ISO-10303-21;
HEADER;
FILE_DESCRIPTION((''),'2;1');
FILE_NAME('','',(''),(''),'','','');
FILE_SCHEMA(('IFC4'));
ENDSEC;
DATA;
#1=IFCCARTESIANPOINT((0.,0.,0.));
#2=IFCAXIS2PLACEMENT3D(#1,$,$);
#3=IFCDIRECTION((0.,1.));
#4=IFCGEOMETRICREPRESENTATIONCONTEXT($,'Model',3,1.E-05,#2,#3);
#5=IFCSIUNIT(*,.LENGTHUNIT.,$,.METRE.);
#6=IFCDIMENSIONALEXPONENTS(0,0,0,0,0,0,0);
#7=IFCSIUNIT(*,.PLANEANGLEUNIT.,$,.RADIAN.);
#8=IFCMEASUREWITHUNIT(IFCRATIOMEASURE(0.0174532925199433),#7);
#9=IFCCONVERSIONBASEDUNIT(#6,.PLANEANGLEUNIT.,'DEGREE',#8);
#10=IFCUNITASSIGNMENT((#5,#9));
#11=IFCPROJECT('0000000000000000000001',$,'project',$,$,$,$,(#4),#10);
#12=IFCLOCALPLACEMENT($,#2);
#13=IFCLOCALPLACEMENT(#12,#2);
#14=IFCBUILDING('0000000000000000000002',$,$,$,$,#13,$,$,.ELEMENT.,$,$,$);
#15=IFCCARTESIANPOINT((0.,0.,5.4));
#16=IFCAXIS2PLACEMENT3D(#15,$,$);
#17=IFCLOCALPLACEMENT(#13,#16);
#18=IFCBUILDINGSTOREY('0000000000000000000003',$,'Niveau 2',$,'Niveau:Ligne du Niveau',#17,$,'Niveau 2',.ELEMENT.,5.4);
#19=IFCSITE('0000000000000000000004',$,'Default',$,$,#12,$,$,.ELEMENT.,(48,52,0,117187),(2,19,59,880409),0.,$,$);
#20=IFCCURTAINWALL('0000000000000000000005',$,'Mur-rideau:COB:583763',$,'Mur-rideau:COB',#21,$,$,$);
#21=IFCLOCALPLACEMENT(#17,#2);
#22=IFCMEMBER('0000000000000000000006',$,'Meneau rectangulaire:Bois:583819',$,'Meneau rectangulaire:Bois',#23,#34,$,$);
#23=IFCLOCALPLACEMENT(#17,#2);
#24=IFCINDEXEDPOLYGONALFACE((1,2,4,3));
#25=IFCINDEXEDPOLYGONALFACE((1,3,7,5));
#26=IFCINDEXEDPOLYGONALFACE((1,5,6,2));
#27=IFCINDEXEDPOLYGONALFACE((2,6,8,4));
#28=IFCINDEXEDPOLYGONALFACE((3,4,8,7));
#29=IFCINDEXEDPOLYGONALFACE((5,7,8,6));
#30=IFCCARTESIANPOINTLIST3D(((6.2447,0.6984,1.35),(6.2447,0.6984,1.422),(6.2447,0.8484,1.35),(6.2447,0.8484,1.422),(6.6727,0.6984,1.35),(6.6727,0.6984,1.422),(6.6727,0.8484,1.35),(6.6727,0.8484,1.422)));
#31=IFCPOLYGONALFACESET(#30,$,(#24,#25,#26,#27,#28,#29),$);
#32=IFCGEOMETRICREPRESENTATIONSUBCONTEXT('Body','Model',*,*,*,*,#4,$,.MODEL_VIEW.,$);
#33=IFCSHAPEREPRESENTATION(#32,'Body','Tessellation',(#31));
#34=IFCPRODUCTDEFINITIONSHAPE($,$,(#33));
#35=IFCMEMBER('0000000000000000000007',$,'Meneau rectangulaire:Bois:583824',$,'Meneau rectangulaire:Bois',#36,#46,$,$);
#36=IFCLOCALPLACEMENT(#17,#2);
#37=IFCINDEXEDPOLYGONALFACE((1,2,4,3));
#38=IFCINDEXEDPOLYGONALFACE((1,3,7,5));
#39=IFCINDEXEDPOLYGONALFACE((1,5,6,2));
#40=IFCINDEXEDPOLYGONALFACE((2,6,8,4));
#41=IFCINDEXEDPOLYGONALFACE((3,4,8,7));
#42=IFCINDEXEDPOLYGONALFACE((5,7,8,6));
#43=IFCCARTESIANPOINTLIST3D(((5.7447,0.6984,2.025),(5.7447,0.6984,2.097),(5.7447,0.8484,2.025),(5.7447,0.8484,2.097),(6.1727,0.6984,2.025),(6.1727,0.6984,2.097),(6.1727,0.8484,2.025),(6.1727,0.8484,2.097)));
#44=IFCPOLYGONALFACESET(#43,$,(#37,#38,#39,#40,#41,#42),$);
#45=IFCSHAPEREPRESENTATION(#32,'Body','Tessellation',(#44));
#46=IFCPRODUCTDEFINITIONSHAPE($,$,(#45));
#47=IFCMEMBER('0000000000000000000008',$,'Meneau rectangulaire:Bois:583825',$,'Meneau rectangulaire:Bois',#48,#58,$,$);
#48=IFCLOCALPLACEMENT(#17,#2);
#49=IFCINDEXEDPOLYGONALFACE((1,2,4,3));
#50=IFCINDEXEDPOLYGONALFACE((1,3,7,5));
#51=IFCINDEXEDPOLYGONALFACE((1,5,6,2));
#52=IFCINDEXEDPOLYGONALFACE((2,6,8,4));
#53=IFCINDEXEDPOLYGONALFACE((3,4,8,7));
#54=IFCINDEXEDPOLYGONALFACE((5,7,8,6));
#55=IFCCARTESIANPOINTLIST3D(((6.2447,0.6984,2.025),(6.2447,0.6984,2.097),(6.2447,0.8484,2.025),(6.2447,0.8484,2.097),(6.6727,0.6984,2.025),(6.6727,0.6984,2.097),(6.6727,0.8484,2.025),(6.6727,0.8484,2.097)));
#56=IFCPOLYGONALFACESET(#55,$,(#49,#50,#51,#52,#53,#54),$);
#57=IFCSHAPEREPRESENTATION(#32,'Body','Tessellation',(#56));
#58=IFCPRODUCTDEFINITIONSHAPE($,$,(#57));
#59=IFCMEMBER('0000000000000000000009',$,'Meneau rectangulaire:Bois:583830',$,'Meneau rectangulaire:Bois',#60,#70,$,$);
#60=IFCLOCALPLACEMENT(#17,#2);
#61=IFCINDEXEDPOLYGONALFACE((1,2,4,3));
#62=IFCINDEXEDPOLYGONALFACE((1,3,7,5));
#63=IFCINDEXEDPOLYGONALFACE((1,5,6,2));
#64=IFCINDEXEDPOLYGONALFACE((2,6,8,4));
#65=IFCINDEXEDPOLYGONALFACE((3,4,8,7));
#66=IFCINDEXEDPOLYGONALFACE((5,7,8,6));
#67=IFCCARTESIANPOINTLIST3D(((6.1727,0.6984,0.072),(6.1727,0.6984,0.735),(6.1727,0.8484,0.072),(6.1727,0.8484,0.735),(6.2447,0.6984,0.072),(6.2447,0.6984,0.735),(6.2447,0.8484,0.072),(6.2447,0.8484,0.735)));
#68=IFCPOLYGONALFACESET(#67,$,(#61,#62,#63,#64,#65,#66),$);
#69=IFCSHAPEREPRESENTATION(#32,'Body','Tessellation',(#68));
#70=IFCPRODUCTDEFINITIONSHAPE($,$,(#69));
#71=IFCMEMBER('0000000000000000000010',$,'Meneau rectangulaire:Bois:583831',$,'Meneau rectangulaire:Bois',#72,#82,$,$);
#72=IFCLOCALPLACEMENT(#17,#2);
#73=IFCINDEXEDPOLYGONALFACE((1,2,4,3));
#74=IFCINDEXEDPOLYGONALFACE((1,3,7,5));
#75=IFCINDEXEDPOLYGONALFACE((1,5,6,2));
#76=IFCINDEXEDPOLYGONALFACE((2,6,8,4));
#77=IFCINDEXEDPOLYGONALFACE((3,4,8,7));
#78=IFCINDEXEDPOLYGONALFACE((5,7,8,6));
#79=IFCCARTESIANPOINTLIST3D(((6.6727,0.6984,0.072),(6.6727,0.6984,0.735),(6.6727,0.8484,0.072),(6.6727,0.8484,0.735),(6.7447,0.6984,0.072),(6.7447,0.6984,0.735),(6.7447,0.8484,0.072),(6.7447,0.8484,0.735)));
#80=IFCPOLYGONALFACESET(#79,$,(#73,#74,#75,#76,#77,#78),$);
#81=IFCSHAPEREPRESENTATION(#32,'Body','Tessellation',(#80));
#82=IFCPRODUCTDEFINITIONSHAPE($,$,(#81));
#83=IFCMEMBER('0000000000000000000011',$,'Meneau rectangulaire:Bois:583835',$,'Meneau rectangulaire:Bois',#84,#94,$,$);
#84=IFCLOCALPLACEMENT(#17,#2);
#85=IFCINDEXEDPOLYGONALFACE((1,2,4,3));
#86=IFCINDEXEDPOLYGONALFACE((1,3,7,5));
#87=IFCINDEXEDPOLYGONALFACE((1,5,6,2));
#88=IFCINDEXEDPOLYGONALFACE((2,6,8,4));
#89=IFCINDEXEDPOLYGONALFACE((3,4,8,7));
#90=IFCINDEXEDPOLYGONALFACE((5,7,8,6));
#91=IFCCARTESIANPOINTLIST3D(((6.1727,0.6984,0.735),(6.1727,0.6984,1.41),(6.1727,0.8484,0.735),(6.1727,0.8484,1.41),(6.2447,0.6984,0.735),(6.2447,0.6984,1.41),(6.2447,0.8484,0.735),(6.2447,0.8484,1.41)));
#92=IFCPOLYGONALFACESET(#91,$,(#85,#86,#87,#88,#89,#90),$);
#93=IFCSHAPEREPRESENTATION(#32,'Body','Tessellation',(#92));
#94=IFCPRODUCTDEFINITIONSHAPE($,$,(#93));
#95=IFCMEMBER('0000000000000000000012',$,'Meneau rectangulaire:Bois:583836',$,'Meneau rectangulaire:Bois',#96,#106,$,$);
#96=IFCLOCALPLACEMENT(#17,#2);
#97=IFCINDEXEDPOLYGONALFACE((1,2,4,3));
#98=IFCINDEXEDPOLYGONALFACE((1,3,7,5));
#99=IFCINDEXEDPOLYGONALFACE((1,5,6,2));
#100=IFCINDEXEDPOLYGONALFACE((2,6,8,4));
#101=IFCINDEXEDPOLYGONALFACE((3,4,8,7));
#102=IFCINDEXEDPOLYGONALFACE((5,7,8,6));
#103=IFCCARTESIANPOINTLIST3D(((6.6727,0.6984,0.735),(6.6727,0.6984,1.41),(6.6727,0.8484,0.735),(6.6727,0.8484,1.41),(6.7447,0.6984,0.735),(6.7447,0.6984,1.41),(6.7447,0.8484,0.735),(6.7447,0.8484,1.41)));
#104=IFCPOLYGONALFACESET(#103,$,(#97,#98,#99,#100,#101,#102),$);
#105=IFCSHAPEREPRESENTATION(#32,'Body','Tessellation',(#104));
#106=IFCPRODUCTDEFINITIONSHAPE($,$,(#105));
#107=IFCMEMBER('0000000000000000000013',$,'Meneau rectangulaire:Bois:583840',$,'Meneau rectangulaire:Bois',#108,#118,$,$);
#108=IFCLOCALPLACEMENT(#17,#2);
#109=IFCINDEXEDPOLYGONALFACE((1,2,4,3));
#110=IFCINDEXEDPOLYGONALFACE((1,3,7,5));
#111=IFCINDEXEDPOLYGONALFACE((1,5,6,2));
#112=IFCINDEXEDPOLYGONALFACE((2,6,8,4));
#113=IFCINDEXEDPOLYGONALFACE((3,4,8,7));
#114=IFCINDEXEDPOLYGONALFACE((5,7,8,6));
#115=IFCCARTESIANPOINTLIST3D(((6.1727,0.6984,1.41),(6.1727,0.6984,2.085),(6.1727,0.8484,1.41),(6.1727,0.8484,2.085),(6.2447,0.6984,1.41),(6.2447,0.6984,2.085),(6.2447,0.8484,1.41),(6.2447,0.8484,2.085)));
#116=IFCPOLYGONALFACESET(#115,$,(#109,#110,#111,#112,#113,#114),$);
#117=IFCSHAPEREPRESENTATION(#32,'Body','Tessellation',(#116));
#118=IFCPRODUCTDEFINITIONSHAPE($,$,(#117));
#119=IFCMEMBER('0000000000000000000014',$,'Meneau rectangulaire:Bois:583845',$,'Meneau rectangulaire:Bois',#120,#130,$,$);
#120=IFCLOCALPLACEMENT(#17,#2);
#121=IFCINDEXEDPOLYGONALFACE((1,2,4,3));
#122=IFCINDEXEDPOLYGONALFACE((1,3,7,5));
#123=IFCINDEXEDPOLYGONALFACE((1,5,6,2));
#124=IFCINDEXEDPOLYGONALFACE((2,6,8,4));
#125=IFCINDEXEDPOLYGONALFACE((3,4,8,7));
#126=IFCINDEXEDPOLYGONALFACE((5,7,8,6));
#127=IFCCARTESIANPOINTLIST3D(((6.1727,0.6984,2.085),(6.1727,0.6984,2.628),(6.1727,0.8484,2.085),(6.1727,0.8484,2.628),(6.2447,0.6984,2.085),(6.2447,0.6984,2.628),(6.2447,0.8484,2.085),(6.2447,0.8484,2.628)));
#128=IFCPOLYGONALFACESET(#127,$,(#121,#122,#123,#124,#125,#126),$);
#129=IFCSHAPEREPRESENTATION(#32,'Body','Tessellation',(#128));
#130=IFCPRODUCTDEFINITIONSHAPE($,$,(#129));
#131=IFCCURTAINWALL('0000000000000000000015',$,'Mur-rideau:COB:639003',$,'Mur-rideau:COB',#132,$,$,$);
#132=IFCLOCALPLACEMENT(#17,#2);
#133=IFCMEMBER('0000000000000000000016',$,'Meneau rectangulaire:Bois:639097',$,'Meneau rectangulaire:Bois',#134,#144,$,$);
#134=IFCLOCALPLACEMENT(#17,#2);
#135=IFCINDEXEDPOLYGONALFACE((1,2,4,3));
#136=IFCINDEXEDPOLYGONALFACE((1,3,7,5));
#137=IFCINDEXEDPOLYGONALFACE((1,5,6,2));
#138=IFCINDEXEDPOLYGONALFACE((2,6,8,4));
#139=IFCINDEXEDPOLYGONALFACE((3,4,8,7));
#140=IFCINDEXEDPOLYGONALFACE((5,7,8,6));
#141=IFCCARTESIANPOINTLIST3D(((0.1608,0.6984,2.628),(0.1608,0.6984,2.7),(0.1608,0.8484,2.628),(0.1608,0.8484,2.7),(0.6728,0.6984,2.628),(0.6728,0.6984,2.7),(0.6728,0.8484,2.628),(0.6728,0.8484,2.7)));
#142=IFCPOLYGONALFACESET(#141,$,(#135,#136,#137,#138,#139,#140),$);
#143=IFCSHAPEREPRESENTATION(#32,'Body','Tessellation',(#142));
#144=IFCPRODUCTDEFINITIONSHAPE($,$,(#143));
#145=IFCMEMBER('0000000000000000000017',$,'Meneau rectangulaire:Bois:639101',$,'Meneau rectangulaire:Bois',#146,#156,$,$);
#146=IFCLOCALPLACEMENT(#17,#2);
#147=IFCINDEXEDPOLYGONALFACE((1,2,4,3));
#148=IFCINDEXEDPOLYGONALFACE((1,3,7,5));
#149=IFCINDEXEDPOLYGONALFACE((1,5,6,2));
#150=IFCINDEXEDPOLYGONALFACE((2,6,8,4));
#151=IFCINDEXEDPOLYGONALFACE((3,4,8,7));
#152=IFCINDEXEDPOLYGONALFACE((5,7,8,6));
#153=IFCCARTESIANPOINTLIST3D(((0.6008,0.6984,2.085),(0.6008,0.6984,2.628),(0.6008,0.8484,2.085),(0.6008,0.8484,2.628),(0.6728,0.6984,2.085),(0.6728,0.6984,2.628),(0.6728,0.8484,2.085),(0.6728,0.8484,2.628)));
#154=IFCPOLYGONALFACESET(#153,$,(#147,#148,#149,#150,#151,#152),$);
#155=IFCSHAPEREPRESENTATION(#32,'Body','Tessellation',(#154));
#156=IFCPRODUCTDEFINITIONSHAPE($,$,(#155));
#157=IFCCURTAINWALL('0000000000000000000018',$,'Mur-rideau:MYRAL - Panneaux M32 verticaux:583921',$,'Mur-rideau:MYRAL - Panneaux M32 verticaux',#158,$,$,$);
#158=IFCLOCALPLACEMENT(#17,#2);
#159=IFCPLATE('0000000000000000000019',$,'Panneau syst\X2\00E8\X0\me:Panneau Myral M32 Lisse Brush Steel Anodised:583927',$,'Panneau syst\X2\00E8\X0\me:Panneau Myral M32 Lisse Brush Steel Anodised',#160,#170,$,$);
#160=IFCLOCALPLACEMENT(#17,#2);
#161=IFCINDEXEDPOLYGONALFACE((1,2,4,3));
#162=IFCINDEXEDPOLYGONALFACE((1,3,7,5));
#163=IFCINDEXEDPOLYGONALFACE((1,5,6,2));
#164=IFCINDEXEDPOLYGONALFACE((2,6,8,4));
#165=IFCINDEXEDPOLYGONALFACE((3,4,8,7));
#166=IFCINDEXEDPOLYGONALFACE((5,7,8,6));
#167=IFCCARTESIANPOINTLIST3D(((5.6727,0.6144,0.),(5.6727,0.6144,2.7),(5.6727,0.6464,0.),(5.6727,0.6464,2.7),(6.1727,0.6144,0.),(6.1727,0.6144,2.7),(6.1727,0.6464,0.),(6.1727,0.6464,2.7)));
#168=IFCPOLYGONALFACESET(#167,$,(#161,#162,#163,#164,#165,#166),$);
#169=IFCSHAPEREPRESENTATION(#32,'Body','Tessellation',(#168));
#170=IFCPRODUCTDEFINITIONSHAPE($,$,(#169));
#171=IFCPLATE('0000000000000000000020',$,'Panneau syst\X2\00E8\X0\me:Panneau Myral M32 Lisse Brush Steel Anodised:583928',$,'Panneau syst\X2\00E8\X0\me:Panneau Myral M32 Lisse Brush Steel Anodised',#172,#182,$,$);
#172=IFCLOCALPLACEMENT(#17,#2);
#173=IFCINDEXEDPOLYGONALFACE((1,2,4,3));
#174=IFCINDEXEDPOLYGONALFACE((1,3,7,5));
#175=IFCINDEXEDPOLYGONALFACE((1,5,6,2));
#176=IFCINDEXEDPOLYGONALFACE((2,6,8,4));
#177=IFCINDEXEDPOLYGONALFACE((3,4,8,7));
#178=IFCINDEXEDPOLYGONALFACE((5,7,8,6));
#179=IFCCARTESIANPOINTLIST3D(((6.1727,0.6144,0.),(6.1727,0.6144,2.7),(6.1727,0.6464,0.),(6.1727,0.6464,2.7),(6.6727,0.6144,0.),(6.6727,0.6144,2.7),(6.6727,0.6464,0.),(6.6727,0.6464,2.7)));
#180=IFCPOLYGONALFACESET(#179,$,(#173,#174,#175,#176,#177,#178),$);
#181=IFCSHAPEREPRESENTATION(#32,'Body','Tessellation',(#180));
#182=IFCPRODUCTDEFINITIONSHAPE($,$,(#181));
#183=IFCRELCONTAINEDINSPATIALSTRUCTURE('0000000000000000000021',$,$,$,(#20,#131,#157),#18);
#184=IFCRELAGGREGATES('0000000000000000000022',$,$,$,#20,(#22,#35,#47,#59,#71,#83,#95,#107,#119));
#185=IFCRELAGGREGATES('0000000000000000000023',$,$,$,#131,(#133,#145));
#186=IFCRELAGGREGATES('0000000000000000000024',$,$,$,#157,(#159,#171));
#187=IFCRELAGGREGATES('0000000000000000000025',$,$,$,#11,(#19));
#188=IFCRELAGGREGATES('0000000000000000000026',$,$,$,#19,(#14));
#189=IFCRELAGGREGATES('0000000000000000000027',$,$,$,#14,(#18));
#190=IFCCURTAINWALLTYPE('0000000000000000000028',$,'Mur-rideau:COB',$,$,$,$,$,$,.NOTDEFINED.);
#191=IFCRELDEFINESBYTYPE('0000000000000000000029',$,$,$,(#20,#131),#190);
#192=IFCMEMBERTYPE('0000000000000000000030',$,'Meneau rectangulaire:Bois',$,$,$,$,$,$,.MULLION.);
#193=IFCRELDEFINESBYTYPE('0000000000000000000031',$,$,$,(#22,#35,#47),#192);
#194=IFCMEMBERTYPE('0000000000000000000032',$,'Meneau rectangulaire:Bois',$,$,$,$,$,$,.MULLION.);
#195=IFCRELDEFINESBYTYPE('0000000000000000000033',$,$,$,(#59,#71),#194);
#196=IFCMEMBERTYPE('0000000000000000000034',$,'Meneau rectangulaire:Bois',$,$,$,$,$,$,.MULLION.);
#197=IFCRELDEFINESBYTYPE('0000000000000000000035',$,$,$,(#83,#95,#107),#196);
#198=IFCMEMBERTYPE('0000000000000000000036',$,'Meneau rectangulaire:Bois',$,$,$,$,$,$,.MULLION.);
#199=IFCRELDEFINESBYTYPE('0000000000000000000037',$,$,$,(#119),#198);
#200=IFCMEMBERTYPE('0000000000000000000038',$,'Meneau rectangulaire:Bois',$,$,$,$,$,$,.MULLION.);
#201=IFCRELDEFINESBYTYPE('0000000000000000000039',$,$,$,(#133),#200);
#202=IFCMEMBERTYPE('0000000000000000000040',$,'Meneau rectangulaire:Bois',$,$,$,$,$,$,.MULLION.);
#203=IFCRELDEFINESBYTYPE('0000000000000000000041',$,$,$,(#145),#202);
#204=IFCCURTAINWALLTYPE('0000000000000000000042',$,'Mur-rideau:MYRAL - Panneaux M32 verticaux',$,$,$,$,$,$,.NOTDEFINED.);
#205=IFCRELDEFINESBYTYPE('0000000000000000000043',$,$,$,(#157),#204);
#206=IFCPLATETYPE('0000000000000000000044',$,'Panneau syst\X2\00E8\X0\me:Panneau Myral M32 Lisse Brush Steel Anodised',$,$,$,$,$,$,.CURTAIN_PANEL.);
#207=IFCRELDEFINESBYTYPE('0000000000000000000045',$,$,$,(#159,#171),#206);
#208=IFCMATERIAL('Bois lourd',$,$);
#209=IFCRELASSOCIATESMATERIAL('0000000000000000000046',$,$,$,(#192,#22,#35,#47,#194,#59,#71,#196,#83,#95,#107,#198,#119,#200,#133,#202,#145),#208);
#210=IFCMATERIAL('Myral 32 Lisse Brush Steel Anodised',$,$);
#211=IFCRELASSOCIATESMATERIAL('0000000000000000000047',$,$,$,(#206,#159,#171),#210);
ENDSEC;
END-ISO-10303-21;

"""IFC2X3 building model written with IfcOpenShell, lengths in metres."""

from ifc_helpers import new_model, entity, si_unit, converted_unit, direction, frame, origin, origin_2d_with_axis, place, context, subcontext, project, spatial, rectangle, extrude, source, transform, mapped, material, type_object, type_shapes, element, aggregate, save


model = new_model("IFC2X3")

# Units and contexts
model_context = context("Model", 3, precision=1e-05, world=origin(), true_north=direction((0.0, 1.0)))
body_context = subcontext(model_context, "Body", "Model", "MODEL_VIEW")
ifc_project = project(units=[si_unit("LENGTHUNIT", "METRE"), converted_unit("PLANEANGLEUNIT", "DEGREE", entity("IfcRatioMeasure", 0.0174532925199433), si_unit("PLANEANGLEUNIT", "RADIAN"), dimensions=[0, 0, 0, 0, 0, 0, 0])], contexts=[model_context])

# Site, building, storey
site_placement = place(None, origin())
site = spatial("IfcSite", under=ifc_project, at=site_placement, Name="Default", CompositionType="ELEMENT", RefLatitude=(48, 52, 0, 117187), RefLongitude=(2, 19, 59, 880409), RefElevation=0.0)
building_placement = place(site_placement, origin())
building = spatial("IfcBuilding", under=site, at=building_placement, CompositionType="ELEMENT")
storey_placement = place(building_placement, frame((0.0, 0.0, 5.4)))
storey = spatial("IfcBuildingStorey", under=building, at=storey_placement, Name="Niveau 2", ObjectType="Niveau:Ligne du Niveau", LongName="Niveau 2", CompositionType="ELEMENT", Elevation=5.4)

# Curtain walls, members
curtain_wall_type_1 = type_object("IfcCurtainWallType", Name="Mur-rideau:COB", PredefinedType="NOTDEFINED")
curtain_wall_1_placement = place(storey_placement, frame((0.0, 0.0, -5.4)))
curtain_wall_1 = element("IfcCurtainWall", 1, at=curtain_wall_1_placement, inside=storey, type_object=curtain_wall_type_1, Name="Mur-rideau:COB:583763", ObjectType="Mur-rideau:COB")
ifc_material_1 = material(Name="Bois lourd")
member_type_1 = type_object("IfcMemberType", Name="Meneau rectangulaire:Bois", PredefinedType="MULLION", material=ifc_material_1)
shared_shape_1 = source(origin(), body_context, "Body", "SweptSolid", [
    extrude(rectangle(XDim=0.15, YDim=0.072, at=origin_2d_with_axis()), frame((-0.024, 0.0, -0.428), z_axis=(0.0, 0.0, 1.0), x_axis=(0.0, -1.0, 0.0)), (0.0, 0.0, 1.0), 0.428),
])
type_shapes(member_type_1, [shared_shape_1])
member_1_placement = place(storey_placement, frame((6.6727, 0.7734, 1.41), z_axis=(1.0, 0.0, 0.0), x_axis=(0.0, 0.0, 1.0)))
member_1 = element("IfcMember", 2, at=member_1_placement, type_object=member_type_1, material=ifc_material_1, Name="Meneau rectangulaire:Bois:583819", ObjectType="Meneau rectangulaire:Bois", context=body_context, shape_type="MappedRepresentation", body=[
    mapped(shared_shape_1, transform((0.0, 0.0, 0.0), scale=1.0)),
])
member_2_placement = place(storey_placement, frame((6.1727, 0.7734, 2.085), z_axis=(1.0, 0.0, 0.0), x_axis=(0.0, 0.0, 1.0)))
member_2 = element("IfcMember", 3, at=member_2_placement, type_object=member_type_1, material=ifc_material_1, Name="Meneau rectangulaire:Bois:583824", ObjectType="Meneau rectangulaire:Bois", context=body_context, shape_type="MappedRepresentation", body=[
    mapped(shared_shape_1, transform((0.0, 0.0, 0.0), scale=1.0)),
])
member_3_placement = place(storey_placement, frame((6.6727, 0.7734, 2.085), z_axis=(1.0, 0.0, 0.0), x_axis=(0.0, 0.0, 1.0)))
member_3 = element("IfcMember", 4, at=member_3_placement, type_object=member_type_1, material=ifc_material_1, Name="Meneau rectangulaire:Bois:583825", ObjectType="Meneau rectangulaire:Bois", context=body_context, shape_type="MappedRepresentation", body=[
    mapped(shared_shape_1, transform((0.0, 0.0, 0.0), scale=1.0)),
])
member_type_2 = type_object("IfcMemberType", Name="Meneau rectangulaire:Bois", PredefinedType="MULLION", material=ifc_material_1)
shared_shape_2 = source(origin(), body_context, "Body", "SweptSolid", [
    extrude(rectangle(XDim=0.15, YDim=0.072, at=origin_2d_with_axis()), frame((-0.024, 0.0, -0.663), z_axis=(0.0, 0.0, 1.0), x_axis=(0.0, -1.0, 0.0)), (0.0, 0.0, 1.0), 0.663),
])
type_shapes(member_type_2, [shared_shape_2])
member_4_placement = place(storey_placement, frame((6.2327, 0.7734, 0.072), z_axis=(0.0, 0.0, -1.0), x_axis=(1.0, 0.0, 0.0)))
member_4 = element("IfcMember", 5, at=member_4_placement, type_object=member_type_2, material=ifc_material_1, Name="Meneau rectangulaire:Bois:583830", ObjectType="Meneau rectangulaire:Bois", context=body_context, shape_type="MappedRepresentation", body=[
    mapped(shared_shape_2, transform((0.0, 0.0, 0.0), scale=1.0)),
])
member_5_placement = place(storey_placement, frame((6.7327, 0.7734, 0.072), z_axis=(0.0, 0.0, -1.0), x_axis=(1.0, 0.0, 0.0)))
member_5 = element("IfcMember", 6, at=member_5_placement, type_object=member_type_2, material=ifc_material_1, Name="Meneau rectangulaire:Bois:583831", ObjectType="Meneau rectangulaire:Bois", context=body_context, shape_type="MappedRepresentation", body=[
    mapped(shared_shape_2, transform((0.0, 0.0, 0.0), scale=1.0)),
])
member_type_3 = type_object("IfcMemberType", Name="Meneau rectangulaire:Bois", PredefinedType="MULLION", material=ifc_material_1)
shared_shape_3 = source(origin(), body_context, "Body", "SweptSolid", [
    extrude(rectangle(XDim=0.15, YDim=0.072, at=origin_2d_with_axis()), frame((-0.024, 0.0, -0.675), z_axis=(0.0, 0.0, 1.0), x_axis=(0.0, -1.0, 0.0)), (0.0, 0.0, 1.0), 0.675),
])
type_shapes(member_type_3, [shared_shape_3])
member_6_placement = place(storey_placement, frame((6.2327, 0.7734, 0.735), z_axis=(0.0, 0.0, -1.0), x_axis=(1.0, 0.0, 0.0)))
member_6 = element("IfcMember", 7, at=member_6_placement, type_object=member_type_3, material=ifc_material_1, Name="Meneau rectangulaire:Bois:583835", ObjectType="Meneau rectangulaire:Bois", context=body_context, shape_type="MappedRepresentation", body=[
    mapped(shared_shape_3, transform((0.0, 0.0, 0.0), scale=1.0)),
])
member_7_placement = place(storey_placement, frame((6.7327, 0.7734, 0.735), z_axis=(0.0, 0.0, -1.0), x_axis=(1.0, 0.0, 0.0)))
member_7 = element("IfcMember", 8, at=member_7_placement, type_object=member_type_3, material=ifc_material_1, Name="Meneau rectangulaire:Bois:583836", ObjectType="Meneau rectangulaire:Bois", context=body_context, shape_type="MappedRepresentation", body=[
    mapped(shared_shape_3, transform((0.0, 0.0, 0.0), scale=1.0)),
])
member_8_placement = place(storey_placement, frame((6.2327, 0.7734, 1.41), z_axis=(0.0, 0.0, -1.0), x_axis=(1.0, 0.0, 0.0)))
member_8 = element("IfcMember", 9, at=member_8_placement, type_object=member_type_3, material=ifc_material_1, Name="Meneau rectangulaire:Bois:583840", ObjectType="Meneau rectangulaire:Bois", context=body_context, shape_type="MappedRepresentation", body=[
    mapped(shared_shape_3, transform((0.0, 0.0, 0.0), scale=1.0)),
])
member_type_4 = type_object("IfcMemberType", Name="Meneau rectangulaire:Bois", PredefinedType="MULLION", material=ifc_material_1)
shared_shape_4 = source(origin(), body_context, "Body", "SweptSolid", [
    extrude(rectangle(XDim=0.15, YDim=0.072, at=origin_2d_with_axis()), frame((-0.024, 0.0, -0.543), z_axis=(0.0, 0.0, 1.0), x_axis=(0.0, -1.0, 0.0)), (0.0, 0.0, 1.0), 0.543),
])
type_shapes(member_type_4, [shared_shape_4])
member_9_placement = place(storey_placement, frame((6.2327, 0.7734, 2.085), z_axis=(0.0, 0.0, -1.0), x_axis=(1.0, 0.0, 0.0)))
member_9 = element("IfcMember", 10, at=member_9_placement, type_object=member_type_4, material=ifc_material_1, Name="Meneau rectangulaire:Bois:583845", ObjectType="Meneau rectangulaire:Bois", context=body_context, shape_type="MappedRepresentation", body=[
    mapped(shared_shape_4, transform((0.0, 0.0, 0.0), scale=1.0)),
])
aggregate(curtain_wall_1, [member_1, member_2, member_3, member_4, member_5, member_6, member_7, member_8, member_9])
curtain_wall_2_placement = place(storey_placement, frame((0.0, 0.0, -5.4)))
curtain_wall_2 = element("IfcCurtainWall", 11, at=curtain_wall_2_placement, inside=storey, type_object=curtain_wall_type_1, Name="Mur-rideau:COB:639003", ObjectType="Mur-rideau:COB")
member_type_5 = type_object("IfcMemberType", Name="Meneau rectangulaire:Bois", PredefinedType="MULLION", material=ifc_material_1)
shared_shape_5 = source(origin(), body_context, "Body", "SweptSolid", [
    extrude(rectangle(XDim=0.15, YDim=0.072, at=origin_2d_with_axis()), frame((-0.036, 0.0, -0.512), z_axis=(0.0, 0.0, 1.0), x_axis=(0.0, -1.0, 0.0)), (0.0, 0.0, 1.0), 0.512),
])
type_shapes(member_type_5, [shared_shape_5])
member_10_placement = place(storey_placement, frame((0.6728, 0.7734, 2.7), z_axis=(1.0, 0.0, 0.0), x_axis=(0.0, 0.0, 1.0)))
member_10 = element("IfcMember", 12, at=member_10_placement, type_object=member_type_5, material=ifc_material_1, Name="Meneau rectangulaire:Bois:639097", ObjectType="Meneau rectangulaire:Bois", context=body_context, shape_type="MappedRepresentation", body=[
    mapped(shared_shape_5, transform((0.0, 0.0, 0.0), scale=1.0)),
])
member_type_6 = type_object("IfcMemberType", Name="Meneau rectangulaire:Bois", PredefinedType="MULLION", material=ifc_material_1)
shared_shape_6 = source(origin(), body_context, "Body", "SweptSolid", [
    extrude(rectangle(XDim=0.15, YDim=0.072, at=origin_2d_with_axis()), frame((-0.024, 0.0, -0.543), z_axis=(0.0, 0.0, 1.0), x_axis=(0.0, -1.0, 0.0)), (0.0, 0.0, 1.0), 0.543),
])
type_shapes(member_type_6, [shared_shape_6])
member_11_placement = place(storey_placement, frame((0.6608, 0.7734, 2.085), z_axis=(0.0, 0.0, -1.0), x_axis=(1.0, 0.0, 0.0)))
member_11 = element("IfcMember", 13, at=member_11_placement, type_object=member_type_6, material=ifc_material_1, Name="Meneau rectangulaire:Bois:639101", ObjectType="Meneau rectangulaire:Bois", context=body_context, shape_type="MappedRepresentation", body=[
    mapped(shared_shape_6, transform((0.0, 0.0, 0.0), scale=1.0)),
])
aggregate(curtain_wall_2, [member_10, member_11])

# Curtain wall, plates
curtain_wall_type_2 = type_object("IfcCurtainWallType", Name="Mur-rideau:MYRAL - Panneaux M32 verticaux", PredefinedType="NOTDEFINED")
curtain_wall_3_placement = place(storey_placement, frame((0.0, 0.0, -5.4)))
curtain_wall_3 = element("IfcCurtainWall", 14, at=curtain_wall_3_placement, inside=storey, type_object=curtain_wall_type_2, Name="Mur-rideau:MYRAL - Panneaux M32 verticaux:583921", ObjectType="Mur-rideau:MYRAL - Panneaux M32 verticaux")
ifc_material_2 = material(Name="Myral 32 Lisse Brush Steel Anodised")
plate_type = type_object("IfcPlateType", Name="Panneau système:Panneau Myral M32 Lisse Brush Steel Anodised", PredefinedType="CURTAIN_PANEL", material=ifc_material_2)
shared_shape_7 = source(origin(), body_context, "Body", "SweptSolid", [
    extrude(rectangle(XDim=0.032, YDim=0.5, at=origin_2d_with_axis()), frame((0.0, -0.016, 0.0), z_axis=(0.0, 0.0, 1.0), x_axis=(0.0, 1.0, 0.0)), (0.0, 0.0, 1.0), 2.7),
])
type_shapes(plate_type, [shared_shape_7])
plate_1_placement = place(curtain_wall_3_placement, frame((5.9227, 0.6464, 5.4)))
plate_1 = element("IfcPlate", 15, at=plate_1_placement, type_object=plate_type, material=ifc_material_2, Name="Panneau système:Panneau Myral M32 Lisse Brush Steel Anodised:583927", ObjectType="Panneau système:Panneau Myral M32 Lisse Brush Steel Anodised", context=body_context, shape_type="MappedRepresentation", body=[
    mapped(shared_shape_7, transform((0.0, 0.0, 0.0), scale=1.0)),
])
plate_2_placement = place(curtain_wall_3_placement, frame((6.4227, 0.6464, 5.4)))
plate_2 = element("IfcPlate", 16, at=plate_2_placement, type_object=plate_type, material=ifc_material_2, Name="Panneau système:Panneau Myral M32 Lisse Brush Steel Anodised:583928", ObjectType="Panneau système:Panneau Myral M32 Lisse Brush Steel Anodised", context=body_context, shape_type="MappedRepresentation", body=[
    mapped(shared_shape_7, transform((0.0, 0.0, 0.0), scale=1.0)),
])
aggregate(curtain_wall_3, [plate_1, plate_2])

save(model, "model.ifc")
